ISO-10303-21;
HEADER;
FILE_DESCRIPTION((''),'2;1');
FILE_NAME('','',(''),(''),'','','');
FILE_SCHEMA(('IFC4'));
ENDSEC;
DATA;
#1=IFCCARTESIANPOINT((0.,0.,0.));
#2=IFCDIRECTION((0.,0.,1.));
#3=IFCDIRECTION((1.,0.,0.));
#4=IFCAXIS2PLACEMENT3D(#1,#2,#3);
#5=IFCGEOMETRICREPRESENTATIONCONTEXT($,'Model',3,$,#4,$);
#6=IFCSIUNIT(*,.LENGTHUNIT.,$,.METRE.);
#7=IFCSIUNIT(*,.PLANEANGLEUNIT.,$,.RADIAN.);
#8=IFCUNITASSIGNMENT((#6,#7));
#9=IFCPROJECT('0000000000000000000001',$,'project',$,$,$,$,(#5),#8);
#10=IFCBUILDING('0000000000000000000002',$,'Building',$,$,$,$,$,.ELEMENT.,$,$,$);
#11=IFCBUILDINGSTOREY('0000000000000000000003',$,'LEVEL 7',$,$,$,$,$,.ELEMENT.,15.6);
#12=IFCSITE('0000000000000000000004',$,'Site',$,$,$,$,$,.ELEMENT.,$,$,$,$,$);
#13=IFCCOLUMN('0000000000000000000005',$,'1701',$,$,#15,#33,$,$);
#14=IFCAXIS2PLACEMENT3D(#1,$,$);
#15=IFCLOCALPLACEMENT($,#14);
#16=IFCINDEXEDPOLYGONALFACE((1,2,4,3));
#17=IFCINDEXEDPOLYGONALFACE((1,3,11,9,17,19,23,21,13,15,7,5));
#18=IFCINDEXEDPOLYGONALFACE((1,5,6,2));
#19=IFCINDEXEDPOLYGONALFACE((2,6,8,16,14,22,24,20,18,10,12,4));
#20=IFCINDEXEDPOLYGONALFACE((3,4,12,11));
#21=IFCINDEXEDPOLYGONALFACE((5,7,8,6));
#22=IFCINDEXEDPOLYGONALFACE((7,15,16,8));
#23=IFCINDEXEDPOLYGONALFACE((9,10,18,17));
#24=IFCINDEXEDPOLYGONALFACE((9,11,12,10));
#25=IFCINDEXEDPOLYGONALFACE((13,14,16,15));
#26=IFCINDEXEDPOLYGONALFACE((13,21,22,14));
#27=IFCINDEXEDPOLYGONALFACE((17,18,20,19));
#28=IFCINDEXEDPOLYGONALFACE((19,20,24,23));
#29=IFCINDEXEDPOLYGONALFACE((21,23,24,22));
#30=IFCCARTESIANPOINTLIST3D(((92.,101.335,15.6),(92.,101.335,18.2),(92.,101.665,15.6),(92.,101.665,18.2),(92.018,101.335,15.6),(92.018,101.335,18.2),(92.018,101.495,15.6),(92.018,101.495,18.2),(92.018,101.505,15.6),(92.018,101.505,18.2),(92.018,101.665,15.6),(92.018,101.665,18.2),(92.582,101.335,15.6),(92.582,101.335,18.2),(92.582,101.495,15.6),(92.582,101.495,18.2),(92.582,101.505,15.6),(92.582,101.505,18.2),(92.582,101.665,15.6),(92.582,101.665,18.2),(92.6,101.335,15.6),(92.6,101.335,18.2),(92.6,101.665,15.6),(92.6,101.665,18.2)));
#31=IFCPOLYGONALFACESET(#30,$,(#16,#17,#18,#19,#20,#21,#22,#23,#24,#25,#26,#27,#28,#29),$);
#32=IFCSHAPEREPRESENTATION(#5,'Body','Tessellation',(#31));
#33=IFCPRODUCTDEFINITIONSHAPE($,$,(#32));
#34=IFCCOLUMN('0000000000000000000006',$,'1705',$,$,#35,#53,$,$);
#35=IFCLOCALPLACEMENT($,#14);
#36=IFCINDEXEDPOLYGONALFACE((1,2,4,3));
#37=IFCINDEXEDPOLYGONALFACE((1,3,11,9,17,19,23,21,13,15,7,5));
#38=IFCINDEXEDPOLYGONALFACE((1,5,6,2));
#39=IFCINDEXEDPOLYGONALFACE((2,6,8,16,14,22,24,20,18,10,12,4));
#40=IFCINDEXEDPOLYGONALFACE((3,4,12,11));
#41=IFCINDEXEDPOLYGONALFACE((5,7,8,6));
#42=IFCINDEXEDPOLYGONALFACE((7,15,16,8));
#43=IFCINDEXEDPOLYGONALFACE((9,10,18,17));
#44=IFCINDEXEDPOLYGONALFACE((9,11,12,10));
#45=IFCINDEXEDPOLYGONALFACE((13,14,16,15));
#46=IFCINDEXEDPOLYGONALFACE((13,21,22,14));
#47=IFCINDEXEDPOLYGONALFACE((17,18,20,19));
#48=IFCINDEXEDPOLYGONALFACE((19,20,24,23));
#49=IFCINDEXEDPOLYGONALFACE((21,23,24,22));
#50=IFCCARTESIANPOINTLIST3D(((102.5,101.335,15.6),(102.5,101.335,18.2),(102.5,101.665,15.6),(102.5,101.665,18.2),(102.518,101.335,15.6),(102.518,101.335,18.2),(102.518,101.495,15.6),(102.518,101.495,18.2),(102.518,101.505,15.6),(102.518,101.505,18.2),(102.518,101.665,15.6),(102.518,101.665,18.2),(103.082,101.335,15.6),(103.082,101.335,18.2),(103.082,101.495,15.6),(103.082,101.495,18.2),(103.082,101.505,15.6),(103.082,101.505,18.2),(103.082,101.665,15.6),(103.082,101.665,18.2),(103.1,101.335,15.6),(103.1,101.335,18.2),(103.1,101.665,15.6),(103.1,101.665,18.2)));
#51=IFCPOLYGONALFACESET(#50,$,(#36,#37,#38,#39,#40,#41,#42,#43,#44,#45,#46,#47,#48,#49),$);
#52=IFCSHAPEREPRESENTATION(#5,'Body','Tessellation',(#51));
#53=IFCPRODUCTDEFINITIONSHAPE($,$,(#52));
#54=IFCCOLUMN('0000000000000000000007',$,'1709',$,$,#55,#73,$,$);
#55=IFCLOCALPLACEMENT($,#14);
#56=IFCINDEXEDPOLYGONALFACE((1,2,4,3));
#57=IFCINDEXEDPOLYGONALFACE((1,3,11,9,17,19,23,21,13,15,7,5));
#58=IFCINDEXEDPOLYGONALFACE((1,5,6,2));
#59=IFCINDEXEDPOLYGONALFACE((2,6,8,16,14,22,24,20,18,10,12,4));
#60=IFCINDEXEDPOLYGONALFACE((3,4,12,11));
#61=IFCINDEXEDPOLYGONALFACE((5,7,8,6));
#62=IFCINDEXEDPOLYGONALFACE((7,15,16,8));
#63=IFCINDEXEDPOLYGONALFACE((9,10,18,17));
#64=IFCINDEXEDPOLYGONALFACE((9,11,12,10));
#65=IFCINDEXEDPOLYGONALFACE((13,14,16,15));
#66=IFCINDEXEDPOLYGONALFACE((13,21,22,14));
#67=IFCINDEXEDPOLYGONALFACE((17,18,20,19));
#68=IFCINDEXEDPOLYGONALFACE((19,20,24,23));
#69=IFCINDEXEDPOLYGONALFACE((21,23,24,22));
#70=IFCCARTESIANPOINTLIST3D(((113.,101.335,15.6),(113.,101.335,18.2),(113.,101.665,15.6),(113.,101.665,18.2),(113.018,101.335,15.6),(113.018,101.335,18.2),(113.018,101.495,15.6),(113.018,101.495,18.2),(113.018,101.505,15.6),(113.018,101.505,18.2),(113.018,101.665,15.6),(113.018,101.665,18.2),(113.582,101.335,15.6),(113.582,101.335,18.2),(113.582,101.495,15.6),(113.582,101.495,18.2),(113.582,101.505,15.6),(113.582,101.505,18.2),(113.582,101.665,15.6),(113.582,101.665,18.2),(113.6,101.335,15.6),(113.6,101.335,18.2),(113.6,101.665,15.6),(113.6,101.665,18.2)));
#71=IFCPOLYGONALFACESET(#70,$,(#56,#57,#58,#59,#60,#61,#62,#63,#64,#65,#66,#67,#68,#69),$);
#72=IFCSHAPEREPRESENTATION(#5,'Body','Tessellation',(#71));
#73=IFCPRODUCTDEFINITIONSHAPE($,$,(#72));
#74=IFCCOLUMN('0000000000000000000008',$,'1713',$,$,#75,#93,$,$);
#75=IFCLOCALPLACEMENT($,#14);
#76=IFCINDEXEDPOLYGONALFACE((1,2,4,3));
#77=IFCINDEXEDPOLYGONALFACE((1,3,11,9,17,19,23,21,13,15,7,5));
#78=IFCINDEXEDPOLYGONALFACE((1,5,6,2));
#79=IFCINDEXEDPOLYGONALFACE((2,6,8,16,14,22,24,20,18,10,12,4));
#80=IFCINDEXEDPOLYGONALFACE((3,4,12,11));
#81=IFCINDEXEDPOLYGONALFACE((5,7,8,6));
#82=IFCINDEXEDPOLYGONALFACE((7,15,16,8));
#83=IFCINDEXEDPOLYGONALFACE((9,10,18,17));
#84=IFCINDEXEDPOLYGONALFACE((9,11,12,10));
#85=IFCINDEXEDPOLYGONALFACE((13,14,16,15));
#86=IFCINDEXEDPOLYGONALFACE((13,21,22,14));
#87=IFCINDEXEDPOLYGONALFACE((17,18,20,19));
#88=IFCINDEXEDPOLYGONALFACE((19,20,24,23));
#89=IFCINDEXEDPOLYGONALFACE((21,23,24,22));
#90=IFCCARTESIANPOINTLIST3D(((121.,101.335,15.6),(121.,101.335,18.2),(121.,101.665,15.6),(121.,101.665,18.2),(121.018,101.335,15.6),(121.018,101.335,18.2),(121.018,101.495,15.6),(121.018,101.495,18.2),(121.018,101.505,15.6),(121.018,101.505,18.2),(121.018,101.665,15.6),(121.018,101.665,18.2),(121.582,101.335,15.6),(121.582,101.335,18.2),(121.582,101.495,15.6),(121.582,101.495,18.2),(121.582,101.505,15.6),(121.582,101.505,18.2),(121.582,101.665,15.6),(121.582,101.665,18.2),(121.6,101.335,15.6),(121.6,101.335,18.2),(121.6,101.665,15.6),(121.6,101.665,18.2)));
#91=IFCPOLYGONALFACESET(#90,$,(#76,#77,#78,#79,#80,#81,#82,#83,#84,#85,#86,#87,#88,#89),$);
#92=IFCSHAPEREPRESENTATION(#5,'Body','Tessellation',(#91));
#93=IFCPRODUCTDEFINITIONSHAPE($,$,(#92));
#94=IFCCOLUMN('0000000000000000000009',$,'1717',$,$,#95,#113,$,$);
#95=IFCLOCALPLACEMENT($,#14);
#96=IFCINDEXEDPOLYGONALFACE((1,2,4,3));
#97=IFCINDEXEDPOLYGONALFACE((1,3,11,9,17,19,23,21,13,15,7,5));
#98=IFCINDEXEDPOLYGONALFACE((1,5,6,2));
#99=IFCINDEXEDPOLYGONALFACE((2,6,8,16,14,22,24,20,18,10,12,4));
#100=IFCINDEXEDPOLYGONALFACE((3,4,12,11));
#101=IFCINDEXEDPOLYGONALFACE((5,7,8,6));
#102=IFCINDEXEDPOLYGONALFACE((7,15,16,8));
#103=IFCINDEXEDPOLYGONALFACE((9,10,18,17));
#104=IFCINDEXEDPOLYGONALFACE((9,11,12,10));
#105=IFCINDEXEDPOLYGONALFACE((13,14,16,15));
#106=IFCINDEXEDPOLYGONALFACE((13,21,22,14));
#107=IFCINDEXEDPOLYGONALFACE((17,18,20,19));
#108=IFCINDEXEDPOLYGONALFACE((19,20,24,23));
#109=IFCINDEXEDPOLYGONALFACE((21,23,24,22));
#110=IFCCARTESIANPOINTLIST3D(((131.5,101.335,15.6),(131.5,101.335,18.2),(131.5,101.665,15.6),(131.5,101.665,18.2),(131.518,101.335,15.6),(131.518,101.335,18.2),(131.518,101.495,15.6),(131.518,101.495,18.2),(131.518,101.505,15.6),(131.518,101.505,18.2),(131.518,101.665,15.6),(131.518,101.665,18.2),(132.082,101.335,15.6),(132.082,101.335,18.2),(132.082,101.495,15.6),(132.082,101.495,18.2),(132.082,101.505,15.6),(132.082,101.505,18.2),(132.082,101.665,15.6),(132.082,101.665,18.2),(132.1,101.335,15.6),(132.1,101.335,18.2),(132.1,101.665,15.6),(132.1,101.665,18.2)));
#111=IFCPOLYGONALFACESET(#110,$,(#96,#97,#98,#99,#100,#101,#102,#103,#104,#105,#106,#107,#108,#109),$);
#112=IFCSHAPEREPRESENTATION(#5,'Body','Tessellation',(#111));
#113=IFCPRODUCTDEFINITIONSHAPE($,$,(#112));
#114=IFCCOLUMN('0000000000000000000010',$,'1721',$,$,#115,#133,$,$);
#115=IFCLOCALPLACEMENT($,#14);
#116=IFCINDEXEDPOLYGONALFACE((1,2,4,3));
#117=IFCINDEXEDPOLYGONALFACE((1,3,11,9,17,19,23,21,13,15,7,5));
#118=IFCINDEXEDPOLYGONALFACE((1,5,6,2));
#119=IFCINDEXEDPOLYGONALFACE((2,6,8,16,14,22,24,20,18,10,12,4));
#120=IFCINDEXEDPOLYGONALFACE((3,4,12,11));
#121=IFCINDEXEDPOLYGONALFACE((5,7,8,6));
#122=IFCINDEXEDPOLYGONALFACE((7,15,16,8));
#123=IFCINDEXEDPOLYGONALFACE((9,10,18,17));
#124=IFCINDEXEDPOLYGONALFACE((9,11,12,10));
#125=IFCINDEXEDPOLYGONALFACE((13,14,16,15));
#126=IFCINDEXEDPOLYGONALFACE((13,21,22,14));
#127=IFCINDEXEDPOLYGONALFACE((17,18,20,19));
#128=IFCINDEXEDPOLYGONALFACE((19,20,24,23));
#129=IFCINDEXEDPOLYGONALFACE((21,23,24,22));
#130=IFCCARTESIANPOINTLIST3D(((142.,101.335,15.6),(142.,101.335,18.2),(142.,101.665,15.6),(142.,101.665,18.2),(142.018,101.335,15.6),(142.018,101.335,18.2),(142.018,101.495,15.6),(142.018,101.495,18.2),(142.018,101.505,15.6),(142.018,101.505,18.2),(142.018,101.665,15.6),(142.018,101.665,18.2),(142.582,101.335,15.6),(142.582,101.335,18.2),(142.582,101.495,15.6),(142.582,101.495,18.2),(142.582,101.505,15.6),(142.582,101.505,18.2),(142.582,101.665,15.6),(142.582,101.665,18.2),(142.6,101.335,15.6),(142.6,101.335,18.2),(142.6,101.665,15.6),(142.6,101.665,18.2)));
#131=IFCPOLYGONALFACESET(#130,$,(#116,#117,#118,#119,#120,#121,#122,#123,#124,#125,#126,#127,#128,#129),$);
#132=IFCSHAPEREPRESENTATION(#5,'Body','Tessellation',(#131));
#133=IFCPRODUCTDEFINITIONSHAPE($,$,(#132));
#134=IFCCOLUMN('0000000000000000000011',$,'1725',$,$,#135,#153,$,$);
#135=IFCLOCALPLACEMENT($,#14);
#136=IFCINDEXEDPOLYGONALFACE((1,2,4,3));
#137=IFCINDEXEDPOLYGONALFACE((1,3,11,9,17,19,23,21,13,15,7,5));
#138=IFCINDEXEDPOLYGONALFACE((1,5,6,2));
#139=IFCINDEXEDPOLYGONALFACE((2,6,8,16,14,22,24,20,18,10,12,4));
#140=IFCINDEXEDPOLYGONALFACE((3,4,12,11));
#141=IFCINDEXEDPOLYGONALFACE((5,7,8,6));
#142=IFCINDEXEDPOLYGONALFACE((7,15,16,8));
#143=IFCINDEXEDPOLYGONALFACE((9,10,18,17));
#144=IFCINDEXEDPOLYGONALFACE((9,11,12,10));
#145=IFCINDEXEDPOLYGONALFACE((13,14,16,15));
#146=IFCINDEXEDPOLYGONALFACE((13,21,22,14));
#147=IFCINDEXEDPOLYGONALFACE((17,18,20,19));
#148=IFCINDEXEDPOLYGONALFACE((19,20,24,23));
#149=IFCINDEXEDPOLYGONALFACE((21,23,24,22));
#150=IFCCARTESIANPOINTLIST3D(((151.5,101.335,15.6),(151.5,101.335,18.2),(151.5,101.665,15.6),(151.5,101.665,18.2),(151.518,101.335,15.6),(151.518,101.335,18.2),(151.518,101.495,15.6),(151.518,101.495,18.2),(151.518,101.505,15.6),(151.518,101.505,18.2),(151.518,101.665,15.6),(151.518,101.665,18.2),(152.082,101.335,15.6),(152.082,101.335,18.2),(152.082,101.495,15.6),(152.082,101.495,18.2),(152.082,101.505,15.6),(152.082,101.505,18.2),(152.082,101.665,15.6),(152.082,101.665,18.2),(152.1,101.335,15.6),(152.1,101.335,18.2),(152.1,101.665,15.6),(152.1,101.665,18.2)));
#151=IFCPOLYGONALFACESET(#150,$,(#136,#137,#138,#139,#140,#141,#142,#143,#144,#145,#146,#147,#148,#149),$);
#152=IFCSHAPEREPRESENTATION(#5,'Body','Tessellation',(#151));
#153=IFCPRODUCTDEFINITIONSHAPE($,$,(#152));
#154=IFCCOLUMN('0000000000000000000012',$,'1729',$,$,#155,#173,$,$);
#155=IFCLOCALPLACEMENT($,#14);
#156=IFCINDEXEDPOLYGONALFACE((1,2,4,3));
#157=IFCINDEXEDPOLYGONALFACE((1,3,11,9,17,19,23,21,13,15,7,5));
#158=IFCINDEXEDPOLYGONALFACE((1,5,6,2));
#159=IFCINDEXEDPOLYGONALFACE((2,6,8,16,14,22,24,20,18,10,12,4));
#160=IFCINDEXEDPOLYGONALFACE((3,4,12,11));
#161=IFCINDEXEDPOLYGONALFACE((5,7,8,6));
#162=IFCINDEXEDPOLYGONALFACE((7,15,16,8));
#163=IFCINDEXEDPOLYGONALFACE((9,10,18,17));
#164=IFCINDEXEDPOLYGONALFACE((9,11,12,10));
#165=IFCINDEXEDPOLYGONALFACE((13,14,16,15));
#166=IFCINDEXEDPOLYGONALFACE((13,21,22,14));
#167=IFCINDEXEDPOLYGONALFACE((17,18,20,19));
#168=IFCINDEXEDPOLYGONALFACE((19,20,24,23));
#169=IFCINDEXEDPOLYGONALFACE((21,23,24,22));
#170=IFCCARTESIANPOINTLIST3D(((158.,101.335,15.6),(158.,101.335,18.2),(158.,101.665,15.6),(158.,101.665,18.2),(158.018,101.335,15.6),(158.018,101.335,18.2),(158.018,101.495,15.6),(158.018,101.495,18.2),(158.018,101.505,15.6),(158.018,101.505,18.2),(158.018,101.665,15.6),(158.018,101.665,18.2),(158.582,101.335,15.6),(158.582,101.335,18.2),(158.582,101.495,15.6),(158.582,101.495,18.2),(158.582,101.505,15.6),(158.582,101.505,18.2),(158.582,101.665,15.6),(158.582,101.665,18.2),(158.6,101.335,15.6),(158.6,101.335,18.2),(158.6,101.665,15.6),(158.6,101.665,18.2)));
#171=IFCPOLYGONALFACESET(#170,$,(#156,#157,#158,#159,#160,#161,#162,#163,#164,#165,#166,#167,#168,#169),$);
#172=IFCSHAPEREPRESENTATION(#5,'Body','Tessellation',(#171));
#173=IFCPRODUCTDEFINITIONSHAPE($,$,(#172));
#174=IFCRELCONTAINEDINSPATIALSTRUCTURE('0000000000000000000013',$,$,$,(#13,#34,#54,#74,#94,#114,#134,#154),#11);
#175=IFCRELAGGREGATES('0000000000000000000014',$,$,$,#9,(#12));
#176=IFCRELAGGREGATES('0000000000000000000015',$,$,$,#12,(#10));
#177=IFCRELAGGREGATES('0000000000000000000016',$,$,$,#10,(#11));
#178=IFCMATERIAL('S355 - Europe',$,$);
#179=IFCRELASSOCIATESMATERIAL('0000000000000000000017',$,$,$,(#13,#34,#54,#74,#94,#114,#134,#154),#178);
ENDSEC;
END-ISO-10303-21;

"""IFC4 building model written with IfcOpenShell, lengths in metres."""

from ifc_helpers import new_model, si_unit, frame, origin_with_axes, origin_2d_with_axis, place, context, project, spatial, i_section, extrude, material, material_profile, profile_set, profile_usage, element, save


model = new_model("IFC4")

# Units and contexts
model_context = context("Model", 3, world=origin_with_axes())
ifc_project = project(units=[si_unit("LENGTHUNIT", "METRE"), si_unit("PLANEANGLEUNIT", "RADIAN")], contexts=[model_context])

# Site, building, storey
site = spatial("IfcSite", under=ifc_project, Name="Site", CompositionType="ELEMENT")
building = spatial("IfcBuilding", under=site, Name="Building", CompositionType="ELEMENT")
storey = spatial("IfcBuildingStorey", under=building, Name="LEVEL 7", CompositionType="ELEMENT", Elevation=15.6)

# Columns
ifc_material = material(Name="S355 - Europe")
ifc_material_profile_1 = material_profile(ifc_material, i_section(OverallWidth=0.33, OverallDepth=0.6, WebThickness=0.01, FlangeThickness=0.018, at=origin_2d_with_axis()))
ifc_profile_set_1 = profile_set([ifc_material_profile_1])
ifc_profile_usage_1 = profile_usage(ifc_profile_set_1, cardinal=10)
column_1_placement = place(None, frame((92.3, 101.5, 15.6), z_axis=(0.0, 0.0, 1.0), x_axis=(0.0, -1.0, 0.0)))
element("IfcColumn", 1, at=column_1_placement, inside=storey, material=ifc_profile_usage_1, Name="1701", context=model_context, shape_type="SweptSolid", body=[
    extrude(i_section(OverallWidth=0.33, OverallDepth=0.6, WebThickness=0.01, FlangeThickness=0.018, at=origin_2d_with_axis()), origin_with_axes(), (0.0, 0.0, 1.0), 2.6),
])
ifc_material_profile_2 = material_profile(ifc_material, i_section(OverallWidth=0.33, OverallDepth=0.6, WebThickness=0.01, FlangeThickness=0.018, at=origin_2d_with_axis()))
ifc_profile_set_2 = profile_set([ifc_material_profile_2])
ifc_profile_usage_2 = profile_usage(ifc_profile_set_2, cardinal=10)
column_2_placement = place(None, frame((102.8, 101.5, 15.6), z_axis=(0.0, 0.0, 1.0), x_axis=(0.0, -1.0, 0.0)))
element("IfcColumn", 2, at=column_2_placement, inside=storey, material=ifc_profile_usage_2, Name="1705", context=model_context, shape_type="SweptSolid", body=[
    extrude(i_section(OverallWidth=0.33, OverallDepth=0.6, WebThickness=0.01, FlangeThickness=0.018, at=origin_2d_with_axis()), origin_with_axes(), (0.0, 0.0, 1.0), 2.6),
])
ifc_material_profile_3 = material_profile(ifc_material, i_section(OverallWidth=0.33, OverallDepth=0.6, WebThickness=0.01, FlangeThickness=0.018, at=origin_2d_with_axis()))
ifc_profile_set_3 = profile_set([ifc_material_profile_3])
ifc_profile_usage_3 = profile_usage(ifc_profile_set_3, cardinal=10)
column_3_placement = place(None, frame((113.3, 101.5, 15.6), z_axis=(0.0, 0.0, 1.0), x_axis=(0.0, -1.0, 0.0)))
element("IfcColumn", 3, at=column_3_placement, inside=storey, material=ifc_profile_usage_3, Name="1709", context=model_context, shape_type="SweptSolid", body=[
    extrude(i_section(OverallWidth=0.33, OverallDepth=0.6, WebThickness=0.01, FlangeThickness=0.018, at=origin_2d_with_axis()), origin_with_axes(), (0.0, 0.0, 1.0), 2.6),
])
ifc_material_profile_4 = material_profile(ifc_material, i_section(OverallWidth=0.33, OverallDepth=0.6, WebThickness=0.01, FlangeThickness=0.018, at=origin_2d_with_axis()))
ifc_profile_set_4 = profile_set([ifc_material_profile_4])
ifc_profile_usage_4 = profile_usage(ifc_profile_set_4, cardinal=10)
column_4_placement = place(None, frame((121.3, 101.5, 15.6), z_axis=(0.0, 0.0, 1.0), x_axis=(0.0, -1.0, 0.0)))
element("IfcColumn", 4, at=column_4_placement, inside=storey, material=ifc_profile_usage_4, Name="1713", context=model_context, shape_type="SweptSolid", body=[
    extrude(i_section(OverallWidth=0.33, OverallDepth=0.6, WebThickness=0.01, FlangeThickness=0.018, at=origin_2d_with_axis()), origin_with_axes(), (0.0, 0.0, 1.0), 2.6),
])
ifc_material_profile_5 = material_profile(ifc_material, i_section(OverallWidth=0.33, OverallDepth=0.6, WebThickness=0.01, FlangeThickness=0.018, at=origin_2d_with_axis()))
ifc_profile_set_5 = profile_set([ifc_material_profile_5])
ifc_profile_usage_5 = profile_usage(ifc_profile_set_5, cardinal=10)
column_5_placement = place(None, frame((131.8, 101.5, 15.6), z_axis=(0.0, 0.0, 1.0), x_axis=(0.0, -1.0, 0.0)))
element("IfcColumn", 5, at=column_5_placement, inside=storey, material=ifc_profile_usage_5, Name="1717", context=model_context, shape_type="SweptSolid", body=[
    extrude(i_section(OverallWidth=0.33, OverallDepth=0.6, WebThickness=0.01, FlangeThickness=0.018, at=origin_2d_with_axis()), origin_with_axes(), (0.0, 0.0, 1.0), 2.6),
])
ifc_material_profile_6 = material_profile(ifc_material, i_section(OverallWidth=0.33, OverallDepth=0.6, WebThickness=0.01, FlangeThickness=0.018, at=origin_2d_with_axis()))
ifc_profile_set_6 = profile_set([ifc_material_profile_6])
ifc_profile_usage_6 = profile_usage(ifc_profile_set_6, cardinal=10)
column_6_placement = place(None, frame((142.3, 101.5, 15.6), z_axis=(0.0, 0.0, 1.0), x_axis=(0.0, -1.0, 0.0)))
element("IfcColumn", 6, at=column_6_placement, inside=storey, material=ifc_profile_usage_6, Name="1721", context=model_context, shape_type="SweptSolid", body=[
    extrude(i_section(OverallWidth=0.33, OverallDepth=0.6, WebThickness=0.01, FlangeThickness=0.018, at=origin_2d_with_axis()), origin_with_axes(), (0.0, 0.0, 1.0), 2.6),
])
ifc_material_profile_7 = material_profile(ifc_material, i_section(OverallWidth=0.33, OverallDepth=0.6, WebThickness=0.01, FlangeThickness=0.018, at=origin_2d_with_axis()))
ifc_profile_set_7 = profile_set([ifc_material_profile_7])
ifc_profile_usage_7 = profile_usage(ifc_profile_set_7, cardinal=10)
column_7_placement = place(None, frame((151.8, 101.5, 15.6), z_axis=(0.0, 0.0, 1.0), x_axis=(0.0, -1.0, 0.0)))
element("IfcColumn", 7, at=column_7_placement, inside=storey, material=ifc_profile_usage_7, Name="1725", context=model_context, shape_type="SweptSolid", body=[
    extrude(i_section(OverallWidth=0.33, OverallDepth=0.6, WebThickness=0.01, FlangeThickness=0.018, at=origin_2d_with_axis()), origin_with_axes(), (0.0, 0.0, 1.0), 2.6),
])
ifc_material_profile_8 = material_profile(ifc_material, i_section(OverallWidth=0.33, OverallDepth=0.6, WebThickness=0.01, FlangeThickness=0.018, at=origin_2d_with_axis()))
ifc_profile_set_8 = profile_set([ifc_material_profile_8])
ifc_profile_usage_8 = profile_usage(ifc_profile_set_8, cardinal=10)
column_8_placement = place(None, frame((158.3, 101.5, 15.6), z_axis=(0.0, 0.0, 1.0), x_axis=(0.0, -1.0, 0.0)))
element("IfcColumn", 8, at=column_8_placement, inside=storey, material=ifc_profile_usage_8, Name="1729", context=model_context, shape_type="SweptSolid", body=[
    extrude(i_section(OverallWidth=0.33, OverallDepth=0.6, WebThickness=0.01, FlangeThickness=0.018, at=origin_2d_with_axis()), origin_with_axes(), (0.0, 0.0, 1.0), 2.6),
])

save(model, "model.ifc")
